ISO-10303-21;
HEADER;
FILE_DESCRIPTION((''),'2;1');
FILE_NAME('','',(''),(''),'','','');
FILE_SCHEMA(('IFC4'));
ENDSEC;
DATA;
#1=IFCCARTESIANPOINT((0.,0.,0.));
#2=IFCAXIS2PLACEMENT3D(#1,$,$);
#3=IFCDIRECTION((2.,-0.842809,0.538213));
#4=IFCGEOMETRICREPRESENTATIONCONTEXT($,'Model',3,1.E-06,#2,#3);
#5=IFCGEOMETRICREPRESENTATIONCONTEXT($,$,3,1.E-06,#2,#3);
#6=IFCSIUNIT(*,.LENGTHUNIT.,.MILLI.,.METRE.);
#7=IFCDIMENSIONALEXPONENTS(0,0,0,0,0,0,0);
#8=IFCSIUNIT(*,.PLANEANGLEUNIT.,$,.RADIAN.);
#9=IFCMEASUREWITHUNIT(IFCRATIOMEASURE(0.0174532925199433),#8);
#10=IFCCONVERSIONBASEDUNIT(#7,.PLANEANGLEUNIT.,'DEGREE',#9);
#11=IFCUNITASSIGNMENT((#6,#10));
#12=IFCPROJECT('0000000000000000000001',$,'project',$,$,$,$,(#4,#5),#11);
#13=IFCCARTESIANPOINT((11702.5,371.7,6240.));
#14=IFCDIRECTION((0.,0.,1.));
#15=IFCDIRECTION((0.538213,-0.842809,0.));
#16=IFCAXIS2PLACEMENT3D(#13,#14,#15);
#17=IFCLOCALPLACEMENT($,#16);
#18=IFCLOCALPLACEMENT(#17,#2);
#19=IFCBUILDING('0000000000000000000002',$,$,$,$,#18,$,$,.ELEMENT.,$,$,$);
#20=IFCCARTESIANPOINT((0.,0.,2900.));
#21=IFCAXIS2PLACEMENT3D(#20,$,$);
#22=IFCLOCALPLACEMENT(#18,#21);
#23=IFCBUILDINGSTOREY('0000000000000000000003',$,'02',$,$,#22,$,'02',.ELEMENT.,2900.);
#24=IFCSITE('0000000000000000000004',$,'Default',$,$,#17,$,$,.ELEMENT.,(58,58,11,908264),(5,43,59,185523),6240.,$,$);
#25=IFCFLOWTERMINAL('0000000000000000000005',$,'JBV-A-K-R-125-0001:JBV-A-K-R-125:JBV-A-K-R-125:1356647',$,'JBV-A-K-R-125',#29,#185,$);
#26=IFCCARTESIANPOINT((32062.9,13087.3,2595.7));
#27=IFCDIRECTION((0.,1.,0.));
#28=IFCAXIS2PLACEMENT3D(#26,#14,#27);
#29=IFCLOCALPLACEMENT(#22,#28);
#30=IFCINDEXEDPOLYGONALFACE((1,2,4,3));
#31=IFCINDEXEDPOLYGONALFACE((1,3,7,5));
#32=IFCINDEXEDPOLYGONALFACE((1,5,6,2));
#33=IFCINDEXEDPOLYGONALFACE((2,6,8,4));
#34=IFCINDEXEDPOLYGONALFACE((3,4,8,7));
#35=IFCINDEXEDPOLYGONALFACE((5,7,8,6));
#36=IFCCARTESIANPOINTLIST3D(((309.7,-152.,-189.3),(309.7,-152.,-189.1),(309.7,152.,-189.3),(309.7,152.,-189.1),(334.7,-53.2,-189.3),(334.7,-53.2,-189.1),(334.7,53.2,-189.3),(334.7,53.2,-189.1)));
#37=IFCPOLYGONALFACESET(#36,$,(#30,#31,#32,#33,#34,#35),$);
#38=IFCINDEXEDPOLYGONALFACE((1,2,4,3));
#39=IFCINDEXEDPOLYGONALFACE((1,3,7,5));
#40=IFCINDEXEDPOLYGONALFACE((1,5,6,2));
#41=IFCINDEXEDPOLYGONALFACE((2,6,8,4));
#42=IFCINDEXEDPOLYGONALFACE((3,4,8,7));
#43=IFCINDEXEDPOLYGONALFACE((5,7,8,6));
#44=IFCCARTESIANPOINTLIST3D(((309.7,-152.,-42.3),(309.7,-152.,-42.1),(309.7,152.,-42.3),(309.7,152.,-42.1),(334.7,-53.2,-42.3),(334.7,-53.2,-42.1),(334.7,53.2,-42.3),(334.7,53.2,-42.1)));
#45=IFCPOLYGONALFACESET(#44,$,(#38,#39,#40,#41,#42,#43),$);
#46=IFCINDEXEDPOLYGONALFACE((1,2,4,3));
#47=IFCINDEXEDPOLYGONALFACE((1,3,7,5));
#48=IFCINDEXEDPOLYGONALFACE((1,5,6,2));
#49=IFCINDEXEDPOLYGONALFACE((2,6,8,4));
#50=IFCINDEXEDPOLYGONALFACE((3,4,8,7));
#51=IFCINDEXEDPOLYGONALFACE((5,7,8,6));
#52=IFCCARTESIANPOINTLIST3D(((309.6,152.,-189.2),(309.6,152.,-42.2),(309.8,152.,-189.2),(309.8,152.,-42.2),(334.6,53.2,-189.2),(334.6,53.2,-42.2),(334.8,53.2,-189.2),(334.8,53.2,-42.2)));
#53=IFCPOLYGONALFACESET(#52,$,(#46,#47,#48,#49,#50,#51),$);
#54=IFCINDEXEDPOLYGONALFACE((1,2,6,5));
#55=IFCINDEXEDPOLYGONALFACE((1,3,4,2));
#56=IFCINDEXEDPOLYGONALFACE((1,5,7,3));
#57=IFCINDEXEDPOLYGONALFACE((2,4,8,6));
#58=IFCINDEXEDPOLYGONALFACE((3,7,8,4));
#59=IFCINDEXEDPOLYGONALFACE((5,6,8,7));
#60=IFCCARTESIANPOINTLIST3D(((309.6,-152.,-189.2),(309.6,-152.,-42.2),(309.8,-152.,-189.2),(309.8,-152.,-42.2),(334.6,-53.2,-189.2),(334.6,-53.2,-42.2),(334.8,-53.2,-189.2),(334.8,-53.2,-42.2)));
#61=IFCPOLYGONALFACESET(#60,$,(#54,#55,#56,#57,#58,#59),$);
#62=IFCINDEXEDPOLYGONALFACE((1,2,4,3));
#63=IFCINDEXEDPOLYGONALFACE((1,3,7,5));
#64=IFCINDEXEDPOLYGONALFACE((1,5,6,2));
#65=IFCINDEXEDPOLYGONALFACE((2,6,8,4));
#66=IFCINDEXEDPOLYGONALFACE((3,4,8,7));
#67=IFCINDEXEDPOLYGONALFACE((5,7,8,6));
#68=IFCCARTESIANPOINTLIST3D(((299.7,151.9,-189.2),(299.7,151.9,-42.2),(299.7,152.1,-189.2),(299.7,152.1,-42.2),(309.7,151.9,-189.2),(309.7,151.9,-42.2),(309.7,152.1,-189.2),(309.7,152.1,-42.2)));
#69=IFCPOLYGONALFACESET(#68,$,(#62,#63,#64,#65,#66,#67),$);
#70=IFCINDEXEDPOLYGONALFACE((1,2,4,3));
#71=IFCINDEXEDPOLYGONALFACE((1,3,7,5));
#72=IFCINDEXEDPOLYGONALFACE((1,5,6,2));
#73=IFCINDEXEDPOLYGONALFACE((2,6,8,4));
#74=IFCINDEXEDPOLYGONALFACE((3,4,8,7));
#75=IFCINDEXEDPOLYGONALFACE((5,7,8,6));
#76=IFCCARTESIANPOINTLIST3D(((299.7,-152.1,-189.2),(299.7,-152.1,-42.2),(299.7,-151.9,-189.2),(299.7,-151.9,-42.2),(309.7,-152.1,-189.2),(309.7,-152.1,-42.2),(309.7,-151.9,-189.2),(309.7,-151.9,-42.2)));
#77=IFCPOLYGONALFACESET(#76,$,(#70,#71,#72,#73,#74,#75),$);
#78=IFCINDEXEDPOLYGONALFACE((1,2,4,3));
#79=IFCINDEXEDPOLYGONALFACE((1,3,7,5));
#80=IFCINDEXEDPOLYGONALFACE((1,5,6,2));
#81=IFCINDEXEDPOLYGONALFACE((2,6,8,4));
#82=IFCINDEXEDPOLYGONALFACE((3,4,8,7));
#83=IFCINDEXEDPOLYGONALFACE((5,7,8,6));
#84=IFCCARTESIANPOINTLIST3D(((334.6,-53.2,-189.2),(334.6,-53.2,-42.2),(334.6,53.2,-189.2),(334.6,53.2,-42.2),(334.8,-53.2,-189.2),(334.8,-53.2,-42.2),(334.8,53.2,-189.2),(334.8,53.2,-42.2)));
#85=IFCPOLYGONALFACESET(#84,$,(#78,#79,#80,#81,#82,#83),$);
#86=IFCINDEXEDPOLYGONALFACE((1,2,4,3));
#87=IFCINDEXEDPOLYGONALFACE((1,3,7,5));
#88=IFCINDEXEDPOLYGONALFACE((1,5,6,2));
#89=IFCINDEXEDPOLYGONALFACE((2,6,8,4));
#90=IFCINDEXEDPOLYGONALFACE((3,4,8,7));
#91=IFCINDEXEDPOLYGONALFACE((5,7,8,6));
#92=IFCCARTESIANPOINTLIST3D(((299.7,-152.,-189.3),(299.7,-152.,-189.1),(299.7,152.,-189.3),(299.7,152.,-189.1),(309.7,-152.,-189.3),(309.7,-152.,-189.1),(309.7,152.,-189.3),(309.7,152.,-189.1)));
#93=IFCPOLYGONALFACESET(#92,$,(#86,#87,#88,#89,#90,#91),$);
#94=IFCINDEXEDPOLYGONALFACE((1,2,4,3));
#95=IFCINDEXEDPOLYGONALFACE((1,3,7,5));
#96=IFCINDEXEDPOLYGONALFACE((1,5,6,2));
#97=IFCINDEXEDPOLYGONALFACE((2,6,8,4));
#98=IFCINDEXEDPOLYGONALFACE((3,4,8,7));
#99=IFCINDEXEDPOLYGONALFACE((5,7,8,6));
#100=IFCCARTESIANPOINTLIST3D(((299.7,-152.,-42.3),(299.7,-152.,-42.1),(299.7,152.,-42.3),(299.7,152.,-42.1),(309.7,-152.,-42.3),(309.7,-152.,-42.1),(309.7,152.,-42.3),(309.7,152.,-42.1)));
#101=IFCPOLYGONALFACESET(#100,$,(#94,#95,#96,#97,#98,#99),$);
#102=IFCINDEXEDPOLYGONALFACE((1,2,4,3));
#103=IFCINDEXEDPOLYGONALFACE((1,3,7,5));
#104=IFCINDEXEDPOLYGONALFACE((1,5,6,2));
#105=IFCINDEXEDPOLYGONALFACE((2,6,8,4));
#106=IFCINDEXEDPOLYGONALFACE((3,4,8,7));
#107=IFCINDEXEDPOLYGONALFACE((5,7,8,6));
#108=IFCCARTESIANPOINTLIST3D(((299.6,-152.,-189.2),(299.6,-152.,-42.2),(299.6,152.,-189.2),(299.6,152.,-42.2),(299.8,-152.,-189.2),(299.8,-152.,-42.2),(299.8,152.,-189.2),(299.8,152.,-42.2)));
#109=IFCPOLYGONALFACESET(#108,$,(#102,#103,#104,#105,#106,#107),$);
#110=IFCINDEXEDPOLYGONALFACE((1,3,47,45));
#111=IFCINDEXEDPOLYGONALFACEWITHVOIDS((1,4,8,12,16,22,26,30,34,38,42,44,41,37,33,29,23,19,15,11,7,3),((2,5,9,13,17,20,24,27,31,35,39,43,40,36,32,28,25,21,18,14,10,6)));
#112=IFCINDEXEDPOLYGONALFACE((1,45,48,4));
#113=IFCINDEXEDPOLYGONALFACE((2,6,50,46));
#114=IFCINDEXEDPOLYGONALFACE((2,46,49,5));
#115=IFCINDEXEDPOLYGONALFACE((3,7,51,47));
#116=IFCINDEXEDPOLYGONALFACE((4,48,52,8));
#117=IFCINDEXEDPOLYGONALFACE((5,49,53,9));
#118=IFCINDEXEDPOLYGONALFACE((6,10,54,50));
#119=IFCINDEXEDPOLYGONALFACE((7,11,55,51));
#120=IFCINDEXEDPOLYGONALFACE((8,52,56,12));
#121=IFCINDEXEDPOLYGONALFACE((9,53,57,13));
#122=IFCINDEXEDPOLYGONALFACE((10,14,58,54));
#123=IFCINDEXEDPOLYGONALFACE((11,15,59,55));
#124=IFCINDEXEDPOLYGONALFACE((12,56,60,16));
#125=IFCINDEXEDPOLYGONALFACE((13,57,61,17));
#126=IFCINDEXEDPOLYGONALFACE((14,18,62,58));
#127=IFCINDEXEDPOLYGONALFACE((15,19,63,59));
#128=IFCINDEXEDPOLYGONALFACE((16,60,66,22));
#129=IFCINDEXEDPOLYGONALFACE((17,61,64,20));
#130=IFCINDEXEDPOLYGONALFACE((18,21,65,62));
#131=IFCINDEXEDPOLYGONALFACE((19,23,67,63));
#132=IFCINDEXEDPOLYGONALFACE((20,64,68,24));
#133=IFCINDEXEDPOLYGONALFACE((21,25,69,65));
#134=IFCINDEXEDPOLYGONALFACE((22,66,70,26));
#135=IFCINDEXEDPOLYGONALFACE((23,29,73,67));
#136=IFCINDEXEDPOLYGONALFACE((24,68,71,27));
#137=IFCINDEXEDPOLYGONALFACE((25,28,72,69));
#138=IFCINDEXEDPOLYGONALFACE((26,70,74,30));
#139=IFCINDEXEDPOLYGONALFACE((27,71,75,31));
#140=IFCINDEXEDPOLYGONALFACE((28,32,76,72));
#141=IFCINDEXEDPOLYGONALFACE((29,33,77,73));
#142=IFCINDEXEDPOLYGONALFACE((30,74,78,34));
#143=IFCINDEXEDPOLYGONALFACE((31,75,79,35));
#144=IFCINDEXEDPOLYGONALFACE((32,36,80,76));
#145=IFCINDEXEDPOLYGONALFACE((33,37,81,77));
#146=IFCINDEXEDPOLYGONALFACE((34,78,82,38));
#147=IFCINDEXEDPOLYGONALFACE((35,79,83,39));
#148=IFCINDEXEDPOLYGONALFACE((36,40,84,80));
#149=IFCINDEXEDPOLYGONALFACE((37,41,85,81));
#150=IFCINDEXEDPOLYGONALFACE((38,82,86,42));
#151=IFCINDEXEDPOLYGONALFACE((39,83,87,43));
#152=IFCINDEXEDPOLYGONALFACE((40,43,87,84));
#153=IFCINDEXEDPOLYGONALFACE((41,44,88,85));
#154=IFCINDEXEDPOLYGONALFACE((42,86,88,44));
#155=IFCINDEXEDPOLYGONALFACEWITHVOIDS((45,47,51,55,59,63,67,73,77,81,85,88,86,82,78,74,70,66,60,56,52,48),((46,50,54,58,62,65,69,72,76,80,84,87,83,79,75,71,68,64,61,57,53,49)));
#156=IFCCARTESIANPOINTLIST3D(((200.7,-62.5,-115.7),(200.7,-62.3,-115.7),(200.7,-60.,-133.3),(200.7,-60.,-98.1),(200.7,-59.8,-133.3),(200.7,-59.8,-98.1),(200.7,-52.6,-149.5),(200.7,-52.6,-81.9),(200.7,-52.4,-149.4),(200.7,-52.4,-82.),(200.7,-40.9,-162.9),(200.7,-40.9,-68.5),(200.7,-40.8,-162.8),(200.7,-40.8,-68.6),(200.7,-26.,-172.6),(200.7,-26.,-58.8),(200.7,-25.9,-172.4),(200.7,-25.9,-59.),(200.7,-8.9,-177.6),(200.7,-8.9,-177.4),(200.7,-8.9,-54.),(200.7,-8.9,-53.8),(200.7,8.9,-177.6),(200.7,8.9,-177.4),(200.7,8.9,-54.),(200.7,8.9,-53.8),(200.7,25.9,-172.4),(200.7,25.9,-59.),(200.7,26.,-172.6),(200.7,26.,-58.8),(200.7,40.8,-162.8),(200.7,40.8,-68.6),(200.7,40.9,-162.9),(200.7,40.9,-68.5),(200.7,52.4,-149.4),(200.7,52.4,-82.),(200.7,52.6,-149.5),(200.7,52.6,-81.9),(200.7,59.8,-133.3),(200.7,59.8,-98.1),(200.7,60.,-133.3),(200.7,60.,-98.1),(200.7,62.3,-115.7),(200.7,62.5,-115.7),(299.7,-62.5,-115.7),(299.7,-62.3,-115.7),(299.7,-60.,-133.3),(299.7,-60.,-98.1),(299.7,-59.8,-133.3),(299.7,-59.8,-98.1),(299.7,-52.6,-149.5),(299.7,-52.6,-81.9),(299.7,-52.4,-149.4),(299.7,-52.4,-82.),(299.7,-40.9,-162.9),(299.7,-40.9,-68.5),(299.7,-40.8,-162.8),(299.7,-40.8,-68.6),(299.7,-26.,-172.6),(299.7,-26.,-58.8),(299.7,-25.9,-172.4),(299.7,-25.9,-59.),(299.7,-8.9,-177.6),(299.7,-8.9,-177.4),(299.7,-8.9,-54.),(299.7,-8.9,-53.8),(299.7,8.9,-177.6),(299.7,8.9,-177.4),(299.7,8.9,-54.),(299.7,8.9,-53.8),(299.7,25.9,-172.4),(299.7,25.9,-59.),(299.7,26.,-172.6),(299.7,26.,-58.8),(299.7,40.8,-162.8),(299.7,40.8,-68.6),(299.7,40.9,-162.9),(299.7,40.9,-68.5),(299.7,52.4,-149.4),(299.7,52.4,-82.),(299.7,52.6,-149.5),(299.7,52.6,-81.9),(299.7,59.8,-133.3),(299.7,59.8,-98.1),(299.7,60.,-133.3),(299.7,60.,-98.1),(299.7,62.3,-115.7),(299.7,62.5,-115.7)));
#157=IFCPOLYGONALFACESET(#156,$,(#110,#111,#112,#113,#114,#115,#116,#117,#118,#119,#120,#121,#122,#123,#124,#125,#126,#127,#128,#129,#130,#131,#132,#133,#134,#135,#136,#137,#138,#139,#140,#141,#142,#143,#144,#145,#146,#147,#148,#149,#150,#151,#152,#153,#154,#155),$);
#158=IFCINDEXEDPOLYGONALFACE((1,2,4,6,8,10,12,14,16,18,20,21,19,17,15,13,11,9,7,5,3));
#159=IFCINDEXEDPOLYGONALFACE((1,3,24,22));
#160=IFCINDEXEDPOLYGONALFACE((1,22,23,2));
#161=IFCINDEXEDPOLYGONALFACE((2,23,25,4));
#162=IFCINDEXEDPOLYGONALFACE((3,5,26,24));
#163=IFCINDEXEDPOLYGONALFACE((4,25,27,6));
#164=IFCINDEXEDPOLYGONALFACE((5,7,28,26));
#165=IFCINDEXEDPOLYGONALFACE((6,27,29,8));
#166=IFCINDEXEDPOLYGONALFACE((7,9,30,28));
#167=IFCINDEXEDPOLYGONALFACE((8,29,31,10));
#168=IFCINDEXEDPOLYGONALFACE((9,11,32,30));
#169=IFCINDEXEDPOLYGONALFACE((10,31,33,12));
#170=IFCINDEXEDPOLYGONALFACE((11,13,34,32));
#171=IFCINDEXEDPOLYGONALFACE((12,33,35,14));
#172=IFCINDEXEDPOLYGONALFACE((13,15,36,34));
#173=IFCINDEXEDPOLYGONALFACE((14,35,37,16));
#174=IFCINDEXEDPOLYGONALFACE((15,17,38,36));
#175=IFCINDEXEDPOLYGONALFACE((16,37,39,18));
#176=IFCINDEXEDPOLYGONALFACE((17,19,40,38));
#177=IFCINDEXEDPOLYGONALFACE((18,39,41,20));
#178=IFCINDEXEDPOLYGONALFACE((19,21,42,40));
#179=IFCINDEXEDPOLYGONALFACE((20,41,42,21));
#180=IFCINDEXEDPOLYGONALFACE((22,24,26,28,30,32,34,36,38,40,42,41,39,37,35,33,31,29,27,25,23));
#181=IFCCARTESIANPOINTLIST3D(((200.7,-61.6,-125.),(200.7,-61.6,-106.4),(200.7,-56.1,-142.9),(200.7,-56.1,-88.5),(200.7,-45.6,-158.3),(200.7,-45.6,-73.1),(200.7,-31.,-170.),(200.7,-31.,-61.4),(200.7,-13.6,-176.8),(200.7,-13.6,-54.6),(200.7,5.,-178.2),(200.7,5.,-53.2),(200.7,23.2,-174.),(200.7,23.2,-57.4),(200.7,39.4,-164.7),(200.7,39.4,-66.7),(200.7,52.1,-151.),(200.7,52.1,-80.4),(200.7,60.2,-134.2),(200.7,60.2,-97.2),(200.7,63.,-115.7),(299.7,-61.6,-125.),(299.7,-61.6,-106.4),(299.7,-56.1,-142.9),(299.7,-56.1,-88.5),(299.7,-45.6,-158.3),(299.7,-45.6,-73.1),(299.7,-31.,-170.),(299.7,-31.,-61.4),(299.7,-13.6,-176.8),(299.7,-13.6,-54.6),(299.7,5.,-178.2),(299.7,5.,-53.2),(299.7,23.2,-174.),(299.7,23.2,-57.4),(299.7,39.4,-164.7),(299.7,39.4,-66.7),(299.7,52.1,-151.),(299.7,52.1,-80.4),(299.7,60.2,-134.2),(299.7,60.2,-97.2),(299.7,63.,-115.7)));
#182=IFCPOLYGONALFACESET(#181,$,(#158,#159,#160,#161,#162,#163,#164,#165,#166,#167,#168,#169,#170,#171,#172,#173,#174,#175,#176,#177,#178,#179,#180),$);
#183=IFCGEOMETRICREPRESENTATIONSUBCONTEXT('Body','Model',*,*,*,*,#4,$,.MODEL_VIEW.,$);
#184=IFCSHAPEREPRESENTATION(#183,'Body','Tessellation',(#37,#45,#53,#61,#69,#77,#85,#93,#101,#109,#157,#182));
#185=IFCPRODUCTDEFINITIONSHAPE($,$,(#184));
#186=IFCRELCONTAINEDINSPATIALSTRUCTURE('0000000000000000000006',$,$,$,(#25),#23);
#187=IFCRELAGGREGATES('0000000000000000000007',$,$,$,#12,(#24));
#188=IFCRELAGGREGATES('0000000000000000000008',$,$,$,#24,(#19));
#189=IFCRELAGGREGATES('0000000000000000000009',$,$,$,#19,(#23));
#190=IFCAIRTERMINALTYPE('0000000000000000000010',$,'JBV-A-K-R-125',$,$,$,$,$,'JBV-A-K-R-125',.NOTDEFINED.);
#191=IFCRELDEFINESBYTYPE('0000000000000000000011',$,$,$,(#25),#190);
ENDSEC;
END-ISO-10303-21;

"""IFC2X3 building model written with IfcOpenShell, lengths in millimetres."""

from ifc_helpers import new_model, entity, si_unit, converted_unit, direction, frame, frame_2d, origin, origin_2d_with_axis, place, context, subcontext, project, spatial, polyline, circle_curve, parameter, trimmed, segment, composite_curve, rectangle, circle, outline, extrude, source, transform, mapped, type_object, type_shapes, element, save


model = new_model("IFC2X3")

# Units and contexts
model_context = context("Model", 3, precision=1e-06, world=origin(), true_north=direction((2.0, -0.842809, 0.538213)))
context_of_model = context(None, 3, precision=1e-06, world=origin(), true_north=direction((2.0, -0.842809, 0.538213)))
body_context = subcontext(model_context, "Body", "Model", "MODEL_VIEW")
ifc_project = project(units=[si_unit("LENGTHUNIT", "METRE", prefix="MILLI"), converted_unit("PLANEANGLEUNIT", "DEGREE", entity("IfcRatioMeasure", 0.0174532925199433), si_unit("PLANEANGLEUNIT", "RADIAN"), dimensions=[0, 0, 0, 0, 0, 0, 0])], contexts=[model_context, context_of_model])

# Site, building, storey
site_placement = place(None, frame((11702.5, 371.7, 6240.0), z_axis=(0.0, 0.0, 1.0), x_axis=(0.538213, -0.842809, 0.0)))
site = spatial("IfcSite", under=ifc_project, at=site_placement, Name="Default", CompositionType="ELEMENT", RefLatitude=(58, 58, 11, 908264), RefLongitude=(5, 43, 59, 185523), RefElevation=6240.0)
building_placement = place(site_placement, origin())
building = spatial("IfcBuilding", under=site, at=building_placement, CompositionType="ELEMENT")
storey_placement = place(building_placement, frame((0.0, 0.0, 2900.0)))
storey = spatial("IfcBuildingStorey", under=building, at=storey_placement, Name="02", LongName="02", CompositionType="ELEMENT", Elevation=2900.0)

# Flow terminal
air_terminal_type_1 = type_object("IfcAirTerminalType", Name="JBV-A-K-R-125", ElementType="JBV-A-K-R-125", PredefinedType="NOTDEFINED")
shared_shape_1 = source(origin(), body_context, "Body", "SweptSolid", [
    extrude(outline(polyline([(-152.0, -12.5), (152.0, -12.5), (53.2, 12.5), (-53.2, 12.5), (-152.0, -12.5)])), frame((322.2, 0.0, -189.3), z_axis=(0.0, 0.0, 1.0), x_axis=(0.0, -1.0, 0.0)), (0.0, 0.0, 1.0), 0.2),
    extrude(outline(polyline([(-152.0, -12.5), (152.0, -12.5), (53.2, 12.5), (-53.2, 12.5), (-152.0, -12.5)])), frame((322.2, 0.0, -42.3), z_axis=(0.0, 0.0, 1.0), x_axis=(0.0, -1.0, 0.0)), (0.0, 0.0, 1.0), 0.2),
    extrude(rectangle(XDim=0.2, YDim=101.9, at=frame_2d((0.0, 0.0), x_axis=(1.0, 0.0))), frame((322.2, 102.6, -189.2), z_axis=(0.0, 0.0, 1.0), x_axis=(0.969446, 0.245305, 0.0)), (0.0, 0.0, 1.0), 147.0),
    extrude(rectangle(XDim=0.2, YDim=101.9, at=frame_2d((0.0, 0.0), x_axis=(1.0, 0.0))), frame((322.2, -102.6, -189.2), z_axis=(0.0, 0.0, 1.0), x_axis=(-0.969446, 0.245305, 0.0)), (0.0, 0.0, 1.0), 147.0),
    extrude(rectangle(XDim=0.2, YDim=10.0, at=frame_2d((0.0, 0.0), x_axis=(1.0, 0.0))), frame((304.7, 152.0, -189.2), z_axis=(0.0, 0.0, 1.0), x_axis=(0.0, 1.0, 0.0)), (0.0, 0.0, 1.0), 147.0),
    extrude(rectangle(XDim=0.2, YDim=10.0, at=frame_2d((0.0, 0.0), x_axis=(1.0, 0.0))), frame((304.7, -152.0, -189.2), z_axis=(0.0, 0.0, 1.0), x_axis=(0.0, 1.0, 0.0)), (0.0, 0.0, 1.0), 147.0),
    extrude(rectangle(XDim=0.2, YDim=106.4, at=frame_2d((0.0, 0.0), x_axis=(1.0, 0.0))), frame((334.7, 0.0, -189.2)), (0.0, 0.0, 1.0), 147.0),
    extrude(rectangle(XDim=304.0, YDim=10.0, at=frame_2d((0.0, 0.0), x_axis=(1.0, 0.0))), frame((304.7, 0.0, -189.3), z_axis=(0.0, 0.0, 1.0), x_axis=(0.0, -1.0, 0.0)), (0.0, 0.0, 1.0), 0.2),
    extrude(rectangle(XDim=304.0, YDim=10.0, at=frame_2d((0.0, 0.0), x_axis=(1.0, 0.0))), frame((304.7, 0.0, -42.3), z_axis=(0.0, 0.0, 1.0), x_axis=(0.0, -1.0, 0.0)), (0.0, 0.0, 1.0), 0.2),
    extrude(rectangle(XDim=0.2, YDim=304.0, at=frame_2d((0.0, 0.0), x_axis=(1.0, 0.0))), frame((299.7, 0.0, -189.2)), (0.0, 0.0, 1.0), 147.0),
    extrude(outline(composite_curve([segment(trimmed(circle_curve(origin_2d_with_axis(), 62.5), [parameter(0.0)], [parameter(180.0)], True, "PARAMETER"), True, "CONTINUOUS"), segment(trimmed(circle_curve(origin_2d_with_axis(), 62.5), [parameter(180.0)], [parameter(360.0)], True, "PARAMETER"), True, "CONTINUOUS")], self_intersect=False), holes=[composite_curve([segment(trimmed(circle_curve(origin_2d_with_axis(), 62.3), [parameter(180.0)], [parameter(360.0)], True, "PARAMETER"), False, "CONTINUOUS"), segment(trimmed(circle_curve(origin_2d_with_axis(), 62.3), [parameter(0.0)], [parameter(180.0)], True, "PARAMETER"), False, "CONTINUOUS")], self_intersect=False)]), frame((200.7, 0.0, -115.7), z_axis=(1.0, 0.0, 0.0), x_axis=(0.0, 1.0, 0.0)), (0.0, 0.0, 1.0), 99.0),
    extrude(circle(Radius=62.6, at=frame_2d((0.0, 0.0), x_axis=(1.0, 0.0))), frame((200.7, 0.3, -115.7), z_axis=(1.0, 0.0, 0.0), x_axis=(0.0, 1.0, 0.0)), (0.0, 0.0, 1.0), 99.0),
])
type_shapes(air_terminal_type_1, [shared_shape_1])
for number, where, z_axis, x_axis, name in (
    (1, (32062.9, 13087.3, 2595.7), (0.0, 0.0, 1.0), (0.0, 1.0, 0.0), "JBV-A-K-R-125-0001:JBV-A-K-R-125:JBV-A-K-R-125:1356647"),
):
    element("IfcFlowTerminal", number, at=place(storey_placement, frame(where, z_axis=z_axis, x_axis=x_axis)), inside=storey, type_object=air_terminal_type_1, Name=name, ObjectType="JBV-A-K-R-125", context=body_context, shape_type="MappedRepresentation", body=[
        mapped(shared_shape_1, transform((0.0, 0.0, 0.0), scale=1.0)),
    ])

save(model, "model.ifc")
